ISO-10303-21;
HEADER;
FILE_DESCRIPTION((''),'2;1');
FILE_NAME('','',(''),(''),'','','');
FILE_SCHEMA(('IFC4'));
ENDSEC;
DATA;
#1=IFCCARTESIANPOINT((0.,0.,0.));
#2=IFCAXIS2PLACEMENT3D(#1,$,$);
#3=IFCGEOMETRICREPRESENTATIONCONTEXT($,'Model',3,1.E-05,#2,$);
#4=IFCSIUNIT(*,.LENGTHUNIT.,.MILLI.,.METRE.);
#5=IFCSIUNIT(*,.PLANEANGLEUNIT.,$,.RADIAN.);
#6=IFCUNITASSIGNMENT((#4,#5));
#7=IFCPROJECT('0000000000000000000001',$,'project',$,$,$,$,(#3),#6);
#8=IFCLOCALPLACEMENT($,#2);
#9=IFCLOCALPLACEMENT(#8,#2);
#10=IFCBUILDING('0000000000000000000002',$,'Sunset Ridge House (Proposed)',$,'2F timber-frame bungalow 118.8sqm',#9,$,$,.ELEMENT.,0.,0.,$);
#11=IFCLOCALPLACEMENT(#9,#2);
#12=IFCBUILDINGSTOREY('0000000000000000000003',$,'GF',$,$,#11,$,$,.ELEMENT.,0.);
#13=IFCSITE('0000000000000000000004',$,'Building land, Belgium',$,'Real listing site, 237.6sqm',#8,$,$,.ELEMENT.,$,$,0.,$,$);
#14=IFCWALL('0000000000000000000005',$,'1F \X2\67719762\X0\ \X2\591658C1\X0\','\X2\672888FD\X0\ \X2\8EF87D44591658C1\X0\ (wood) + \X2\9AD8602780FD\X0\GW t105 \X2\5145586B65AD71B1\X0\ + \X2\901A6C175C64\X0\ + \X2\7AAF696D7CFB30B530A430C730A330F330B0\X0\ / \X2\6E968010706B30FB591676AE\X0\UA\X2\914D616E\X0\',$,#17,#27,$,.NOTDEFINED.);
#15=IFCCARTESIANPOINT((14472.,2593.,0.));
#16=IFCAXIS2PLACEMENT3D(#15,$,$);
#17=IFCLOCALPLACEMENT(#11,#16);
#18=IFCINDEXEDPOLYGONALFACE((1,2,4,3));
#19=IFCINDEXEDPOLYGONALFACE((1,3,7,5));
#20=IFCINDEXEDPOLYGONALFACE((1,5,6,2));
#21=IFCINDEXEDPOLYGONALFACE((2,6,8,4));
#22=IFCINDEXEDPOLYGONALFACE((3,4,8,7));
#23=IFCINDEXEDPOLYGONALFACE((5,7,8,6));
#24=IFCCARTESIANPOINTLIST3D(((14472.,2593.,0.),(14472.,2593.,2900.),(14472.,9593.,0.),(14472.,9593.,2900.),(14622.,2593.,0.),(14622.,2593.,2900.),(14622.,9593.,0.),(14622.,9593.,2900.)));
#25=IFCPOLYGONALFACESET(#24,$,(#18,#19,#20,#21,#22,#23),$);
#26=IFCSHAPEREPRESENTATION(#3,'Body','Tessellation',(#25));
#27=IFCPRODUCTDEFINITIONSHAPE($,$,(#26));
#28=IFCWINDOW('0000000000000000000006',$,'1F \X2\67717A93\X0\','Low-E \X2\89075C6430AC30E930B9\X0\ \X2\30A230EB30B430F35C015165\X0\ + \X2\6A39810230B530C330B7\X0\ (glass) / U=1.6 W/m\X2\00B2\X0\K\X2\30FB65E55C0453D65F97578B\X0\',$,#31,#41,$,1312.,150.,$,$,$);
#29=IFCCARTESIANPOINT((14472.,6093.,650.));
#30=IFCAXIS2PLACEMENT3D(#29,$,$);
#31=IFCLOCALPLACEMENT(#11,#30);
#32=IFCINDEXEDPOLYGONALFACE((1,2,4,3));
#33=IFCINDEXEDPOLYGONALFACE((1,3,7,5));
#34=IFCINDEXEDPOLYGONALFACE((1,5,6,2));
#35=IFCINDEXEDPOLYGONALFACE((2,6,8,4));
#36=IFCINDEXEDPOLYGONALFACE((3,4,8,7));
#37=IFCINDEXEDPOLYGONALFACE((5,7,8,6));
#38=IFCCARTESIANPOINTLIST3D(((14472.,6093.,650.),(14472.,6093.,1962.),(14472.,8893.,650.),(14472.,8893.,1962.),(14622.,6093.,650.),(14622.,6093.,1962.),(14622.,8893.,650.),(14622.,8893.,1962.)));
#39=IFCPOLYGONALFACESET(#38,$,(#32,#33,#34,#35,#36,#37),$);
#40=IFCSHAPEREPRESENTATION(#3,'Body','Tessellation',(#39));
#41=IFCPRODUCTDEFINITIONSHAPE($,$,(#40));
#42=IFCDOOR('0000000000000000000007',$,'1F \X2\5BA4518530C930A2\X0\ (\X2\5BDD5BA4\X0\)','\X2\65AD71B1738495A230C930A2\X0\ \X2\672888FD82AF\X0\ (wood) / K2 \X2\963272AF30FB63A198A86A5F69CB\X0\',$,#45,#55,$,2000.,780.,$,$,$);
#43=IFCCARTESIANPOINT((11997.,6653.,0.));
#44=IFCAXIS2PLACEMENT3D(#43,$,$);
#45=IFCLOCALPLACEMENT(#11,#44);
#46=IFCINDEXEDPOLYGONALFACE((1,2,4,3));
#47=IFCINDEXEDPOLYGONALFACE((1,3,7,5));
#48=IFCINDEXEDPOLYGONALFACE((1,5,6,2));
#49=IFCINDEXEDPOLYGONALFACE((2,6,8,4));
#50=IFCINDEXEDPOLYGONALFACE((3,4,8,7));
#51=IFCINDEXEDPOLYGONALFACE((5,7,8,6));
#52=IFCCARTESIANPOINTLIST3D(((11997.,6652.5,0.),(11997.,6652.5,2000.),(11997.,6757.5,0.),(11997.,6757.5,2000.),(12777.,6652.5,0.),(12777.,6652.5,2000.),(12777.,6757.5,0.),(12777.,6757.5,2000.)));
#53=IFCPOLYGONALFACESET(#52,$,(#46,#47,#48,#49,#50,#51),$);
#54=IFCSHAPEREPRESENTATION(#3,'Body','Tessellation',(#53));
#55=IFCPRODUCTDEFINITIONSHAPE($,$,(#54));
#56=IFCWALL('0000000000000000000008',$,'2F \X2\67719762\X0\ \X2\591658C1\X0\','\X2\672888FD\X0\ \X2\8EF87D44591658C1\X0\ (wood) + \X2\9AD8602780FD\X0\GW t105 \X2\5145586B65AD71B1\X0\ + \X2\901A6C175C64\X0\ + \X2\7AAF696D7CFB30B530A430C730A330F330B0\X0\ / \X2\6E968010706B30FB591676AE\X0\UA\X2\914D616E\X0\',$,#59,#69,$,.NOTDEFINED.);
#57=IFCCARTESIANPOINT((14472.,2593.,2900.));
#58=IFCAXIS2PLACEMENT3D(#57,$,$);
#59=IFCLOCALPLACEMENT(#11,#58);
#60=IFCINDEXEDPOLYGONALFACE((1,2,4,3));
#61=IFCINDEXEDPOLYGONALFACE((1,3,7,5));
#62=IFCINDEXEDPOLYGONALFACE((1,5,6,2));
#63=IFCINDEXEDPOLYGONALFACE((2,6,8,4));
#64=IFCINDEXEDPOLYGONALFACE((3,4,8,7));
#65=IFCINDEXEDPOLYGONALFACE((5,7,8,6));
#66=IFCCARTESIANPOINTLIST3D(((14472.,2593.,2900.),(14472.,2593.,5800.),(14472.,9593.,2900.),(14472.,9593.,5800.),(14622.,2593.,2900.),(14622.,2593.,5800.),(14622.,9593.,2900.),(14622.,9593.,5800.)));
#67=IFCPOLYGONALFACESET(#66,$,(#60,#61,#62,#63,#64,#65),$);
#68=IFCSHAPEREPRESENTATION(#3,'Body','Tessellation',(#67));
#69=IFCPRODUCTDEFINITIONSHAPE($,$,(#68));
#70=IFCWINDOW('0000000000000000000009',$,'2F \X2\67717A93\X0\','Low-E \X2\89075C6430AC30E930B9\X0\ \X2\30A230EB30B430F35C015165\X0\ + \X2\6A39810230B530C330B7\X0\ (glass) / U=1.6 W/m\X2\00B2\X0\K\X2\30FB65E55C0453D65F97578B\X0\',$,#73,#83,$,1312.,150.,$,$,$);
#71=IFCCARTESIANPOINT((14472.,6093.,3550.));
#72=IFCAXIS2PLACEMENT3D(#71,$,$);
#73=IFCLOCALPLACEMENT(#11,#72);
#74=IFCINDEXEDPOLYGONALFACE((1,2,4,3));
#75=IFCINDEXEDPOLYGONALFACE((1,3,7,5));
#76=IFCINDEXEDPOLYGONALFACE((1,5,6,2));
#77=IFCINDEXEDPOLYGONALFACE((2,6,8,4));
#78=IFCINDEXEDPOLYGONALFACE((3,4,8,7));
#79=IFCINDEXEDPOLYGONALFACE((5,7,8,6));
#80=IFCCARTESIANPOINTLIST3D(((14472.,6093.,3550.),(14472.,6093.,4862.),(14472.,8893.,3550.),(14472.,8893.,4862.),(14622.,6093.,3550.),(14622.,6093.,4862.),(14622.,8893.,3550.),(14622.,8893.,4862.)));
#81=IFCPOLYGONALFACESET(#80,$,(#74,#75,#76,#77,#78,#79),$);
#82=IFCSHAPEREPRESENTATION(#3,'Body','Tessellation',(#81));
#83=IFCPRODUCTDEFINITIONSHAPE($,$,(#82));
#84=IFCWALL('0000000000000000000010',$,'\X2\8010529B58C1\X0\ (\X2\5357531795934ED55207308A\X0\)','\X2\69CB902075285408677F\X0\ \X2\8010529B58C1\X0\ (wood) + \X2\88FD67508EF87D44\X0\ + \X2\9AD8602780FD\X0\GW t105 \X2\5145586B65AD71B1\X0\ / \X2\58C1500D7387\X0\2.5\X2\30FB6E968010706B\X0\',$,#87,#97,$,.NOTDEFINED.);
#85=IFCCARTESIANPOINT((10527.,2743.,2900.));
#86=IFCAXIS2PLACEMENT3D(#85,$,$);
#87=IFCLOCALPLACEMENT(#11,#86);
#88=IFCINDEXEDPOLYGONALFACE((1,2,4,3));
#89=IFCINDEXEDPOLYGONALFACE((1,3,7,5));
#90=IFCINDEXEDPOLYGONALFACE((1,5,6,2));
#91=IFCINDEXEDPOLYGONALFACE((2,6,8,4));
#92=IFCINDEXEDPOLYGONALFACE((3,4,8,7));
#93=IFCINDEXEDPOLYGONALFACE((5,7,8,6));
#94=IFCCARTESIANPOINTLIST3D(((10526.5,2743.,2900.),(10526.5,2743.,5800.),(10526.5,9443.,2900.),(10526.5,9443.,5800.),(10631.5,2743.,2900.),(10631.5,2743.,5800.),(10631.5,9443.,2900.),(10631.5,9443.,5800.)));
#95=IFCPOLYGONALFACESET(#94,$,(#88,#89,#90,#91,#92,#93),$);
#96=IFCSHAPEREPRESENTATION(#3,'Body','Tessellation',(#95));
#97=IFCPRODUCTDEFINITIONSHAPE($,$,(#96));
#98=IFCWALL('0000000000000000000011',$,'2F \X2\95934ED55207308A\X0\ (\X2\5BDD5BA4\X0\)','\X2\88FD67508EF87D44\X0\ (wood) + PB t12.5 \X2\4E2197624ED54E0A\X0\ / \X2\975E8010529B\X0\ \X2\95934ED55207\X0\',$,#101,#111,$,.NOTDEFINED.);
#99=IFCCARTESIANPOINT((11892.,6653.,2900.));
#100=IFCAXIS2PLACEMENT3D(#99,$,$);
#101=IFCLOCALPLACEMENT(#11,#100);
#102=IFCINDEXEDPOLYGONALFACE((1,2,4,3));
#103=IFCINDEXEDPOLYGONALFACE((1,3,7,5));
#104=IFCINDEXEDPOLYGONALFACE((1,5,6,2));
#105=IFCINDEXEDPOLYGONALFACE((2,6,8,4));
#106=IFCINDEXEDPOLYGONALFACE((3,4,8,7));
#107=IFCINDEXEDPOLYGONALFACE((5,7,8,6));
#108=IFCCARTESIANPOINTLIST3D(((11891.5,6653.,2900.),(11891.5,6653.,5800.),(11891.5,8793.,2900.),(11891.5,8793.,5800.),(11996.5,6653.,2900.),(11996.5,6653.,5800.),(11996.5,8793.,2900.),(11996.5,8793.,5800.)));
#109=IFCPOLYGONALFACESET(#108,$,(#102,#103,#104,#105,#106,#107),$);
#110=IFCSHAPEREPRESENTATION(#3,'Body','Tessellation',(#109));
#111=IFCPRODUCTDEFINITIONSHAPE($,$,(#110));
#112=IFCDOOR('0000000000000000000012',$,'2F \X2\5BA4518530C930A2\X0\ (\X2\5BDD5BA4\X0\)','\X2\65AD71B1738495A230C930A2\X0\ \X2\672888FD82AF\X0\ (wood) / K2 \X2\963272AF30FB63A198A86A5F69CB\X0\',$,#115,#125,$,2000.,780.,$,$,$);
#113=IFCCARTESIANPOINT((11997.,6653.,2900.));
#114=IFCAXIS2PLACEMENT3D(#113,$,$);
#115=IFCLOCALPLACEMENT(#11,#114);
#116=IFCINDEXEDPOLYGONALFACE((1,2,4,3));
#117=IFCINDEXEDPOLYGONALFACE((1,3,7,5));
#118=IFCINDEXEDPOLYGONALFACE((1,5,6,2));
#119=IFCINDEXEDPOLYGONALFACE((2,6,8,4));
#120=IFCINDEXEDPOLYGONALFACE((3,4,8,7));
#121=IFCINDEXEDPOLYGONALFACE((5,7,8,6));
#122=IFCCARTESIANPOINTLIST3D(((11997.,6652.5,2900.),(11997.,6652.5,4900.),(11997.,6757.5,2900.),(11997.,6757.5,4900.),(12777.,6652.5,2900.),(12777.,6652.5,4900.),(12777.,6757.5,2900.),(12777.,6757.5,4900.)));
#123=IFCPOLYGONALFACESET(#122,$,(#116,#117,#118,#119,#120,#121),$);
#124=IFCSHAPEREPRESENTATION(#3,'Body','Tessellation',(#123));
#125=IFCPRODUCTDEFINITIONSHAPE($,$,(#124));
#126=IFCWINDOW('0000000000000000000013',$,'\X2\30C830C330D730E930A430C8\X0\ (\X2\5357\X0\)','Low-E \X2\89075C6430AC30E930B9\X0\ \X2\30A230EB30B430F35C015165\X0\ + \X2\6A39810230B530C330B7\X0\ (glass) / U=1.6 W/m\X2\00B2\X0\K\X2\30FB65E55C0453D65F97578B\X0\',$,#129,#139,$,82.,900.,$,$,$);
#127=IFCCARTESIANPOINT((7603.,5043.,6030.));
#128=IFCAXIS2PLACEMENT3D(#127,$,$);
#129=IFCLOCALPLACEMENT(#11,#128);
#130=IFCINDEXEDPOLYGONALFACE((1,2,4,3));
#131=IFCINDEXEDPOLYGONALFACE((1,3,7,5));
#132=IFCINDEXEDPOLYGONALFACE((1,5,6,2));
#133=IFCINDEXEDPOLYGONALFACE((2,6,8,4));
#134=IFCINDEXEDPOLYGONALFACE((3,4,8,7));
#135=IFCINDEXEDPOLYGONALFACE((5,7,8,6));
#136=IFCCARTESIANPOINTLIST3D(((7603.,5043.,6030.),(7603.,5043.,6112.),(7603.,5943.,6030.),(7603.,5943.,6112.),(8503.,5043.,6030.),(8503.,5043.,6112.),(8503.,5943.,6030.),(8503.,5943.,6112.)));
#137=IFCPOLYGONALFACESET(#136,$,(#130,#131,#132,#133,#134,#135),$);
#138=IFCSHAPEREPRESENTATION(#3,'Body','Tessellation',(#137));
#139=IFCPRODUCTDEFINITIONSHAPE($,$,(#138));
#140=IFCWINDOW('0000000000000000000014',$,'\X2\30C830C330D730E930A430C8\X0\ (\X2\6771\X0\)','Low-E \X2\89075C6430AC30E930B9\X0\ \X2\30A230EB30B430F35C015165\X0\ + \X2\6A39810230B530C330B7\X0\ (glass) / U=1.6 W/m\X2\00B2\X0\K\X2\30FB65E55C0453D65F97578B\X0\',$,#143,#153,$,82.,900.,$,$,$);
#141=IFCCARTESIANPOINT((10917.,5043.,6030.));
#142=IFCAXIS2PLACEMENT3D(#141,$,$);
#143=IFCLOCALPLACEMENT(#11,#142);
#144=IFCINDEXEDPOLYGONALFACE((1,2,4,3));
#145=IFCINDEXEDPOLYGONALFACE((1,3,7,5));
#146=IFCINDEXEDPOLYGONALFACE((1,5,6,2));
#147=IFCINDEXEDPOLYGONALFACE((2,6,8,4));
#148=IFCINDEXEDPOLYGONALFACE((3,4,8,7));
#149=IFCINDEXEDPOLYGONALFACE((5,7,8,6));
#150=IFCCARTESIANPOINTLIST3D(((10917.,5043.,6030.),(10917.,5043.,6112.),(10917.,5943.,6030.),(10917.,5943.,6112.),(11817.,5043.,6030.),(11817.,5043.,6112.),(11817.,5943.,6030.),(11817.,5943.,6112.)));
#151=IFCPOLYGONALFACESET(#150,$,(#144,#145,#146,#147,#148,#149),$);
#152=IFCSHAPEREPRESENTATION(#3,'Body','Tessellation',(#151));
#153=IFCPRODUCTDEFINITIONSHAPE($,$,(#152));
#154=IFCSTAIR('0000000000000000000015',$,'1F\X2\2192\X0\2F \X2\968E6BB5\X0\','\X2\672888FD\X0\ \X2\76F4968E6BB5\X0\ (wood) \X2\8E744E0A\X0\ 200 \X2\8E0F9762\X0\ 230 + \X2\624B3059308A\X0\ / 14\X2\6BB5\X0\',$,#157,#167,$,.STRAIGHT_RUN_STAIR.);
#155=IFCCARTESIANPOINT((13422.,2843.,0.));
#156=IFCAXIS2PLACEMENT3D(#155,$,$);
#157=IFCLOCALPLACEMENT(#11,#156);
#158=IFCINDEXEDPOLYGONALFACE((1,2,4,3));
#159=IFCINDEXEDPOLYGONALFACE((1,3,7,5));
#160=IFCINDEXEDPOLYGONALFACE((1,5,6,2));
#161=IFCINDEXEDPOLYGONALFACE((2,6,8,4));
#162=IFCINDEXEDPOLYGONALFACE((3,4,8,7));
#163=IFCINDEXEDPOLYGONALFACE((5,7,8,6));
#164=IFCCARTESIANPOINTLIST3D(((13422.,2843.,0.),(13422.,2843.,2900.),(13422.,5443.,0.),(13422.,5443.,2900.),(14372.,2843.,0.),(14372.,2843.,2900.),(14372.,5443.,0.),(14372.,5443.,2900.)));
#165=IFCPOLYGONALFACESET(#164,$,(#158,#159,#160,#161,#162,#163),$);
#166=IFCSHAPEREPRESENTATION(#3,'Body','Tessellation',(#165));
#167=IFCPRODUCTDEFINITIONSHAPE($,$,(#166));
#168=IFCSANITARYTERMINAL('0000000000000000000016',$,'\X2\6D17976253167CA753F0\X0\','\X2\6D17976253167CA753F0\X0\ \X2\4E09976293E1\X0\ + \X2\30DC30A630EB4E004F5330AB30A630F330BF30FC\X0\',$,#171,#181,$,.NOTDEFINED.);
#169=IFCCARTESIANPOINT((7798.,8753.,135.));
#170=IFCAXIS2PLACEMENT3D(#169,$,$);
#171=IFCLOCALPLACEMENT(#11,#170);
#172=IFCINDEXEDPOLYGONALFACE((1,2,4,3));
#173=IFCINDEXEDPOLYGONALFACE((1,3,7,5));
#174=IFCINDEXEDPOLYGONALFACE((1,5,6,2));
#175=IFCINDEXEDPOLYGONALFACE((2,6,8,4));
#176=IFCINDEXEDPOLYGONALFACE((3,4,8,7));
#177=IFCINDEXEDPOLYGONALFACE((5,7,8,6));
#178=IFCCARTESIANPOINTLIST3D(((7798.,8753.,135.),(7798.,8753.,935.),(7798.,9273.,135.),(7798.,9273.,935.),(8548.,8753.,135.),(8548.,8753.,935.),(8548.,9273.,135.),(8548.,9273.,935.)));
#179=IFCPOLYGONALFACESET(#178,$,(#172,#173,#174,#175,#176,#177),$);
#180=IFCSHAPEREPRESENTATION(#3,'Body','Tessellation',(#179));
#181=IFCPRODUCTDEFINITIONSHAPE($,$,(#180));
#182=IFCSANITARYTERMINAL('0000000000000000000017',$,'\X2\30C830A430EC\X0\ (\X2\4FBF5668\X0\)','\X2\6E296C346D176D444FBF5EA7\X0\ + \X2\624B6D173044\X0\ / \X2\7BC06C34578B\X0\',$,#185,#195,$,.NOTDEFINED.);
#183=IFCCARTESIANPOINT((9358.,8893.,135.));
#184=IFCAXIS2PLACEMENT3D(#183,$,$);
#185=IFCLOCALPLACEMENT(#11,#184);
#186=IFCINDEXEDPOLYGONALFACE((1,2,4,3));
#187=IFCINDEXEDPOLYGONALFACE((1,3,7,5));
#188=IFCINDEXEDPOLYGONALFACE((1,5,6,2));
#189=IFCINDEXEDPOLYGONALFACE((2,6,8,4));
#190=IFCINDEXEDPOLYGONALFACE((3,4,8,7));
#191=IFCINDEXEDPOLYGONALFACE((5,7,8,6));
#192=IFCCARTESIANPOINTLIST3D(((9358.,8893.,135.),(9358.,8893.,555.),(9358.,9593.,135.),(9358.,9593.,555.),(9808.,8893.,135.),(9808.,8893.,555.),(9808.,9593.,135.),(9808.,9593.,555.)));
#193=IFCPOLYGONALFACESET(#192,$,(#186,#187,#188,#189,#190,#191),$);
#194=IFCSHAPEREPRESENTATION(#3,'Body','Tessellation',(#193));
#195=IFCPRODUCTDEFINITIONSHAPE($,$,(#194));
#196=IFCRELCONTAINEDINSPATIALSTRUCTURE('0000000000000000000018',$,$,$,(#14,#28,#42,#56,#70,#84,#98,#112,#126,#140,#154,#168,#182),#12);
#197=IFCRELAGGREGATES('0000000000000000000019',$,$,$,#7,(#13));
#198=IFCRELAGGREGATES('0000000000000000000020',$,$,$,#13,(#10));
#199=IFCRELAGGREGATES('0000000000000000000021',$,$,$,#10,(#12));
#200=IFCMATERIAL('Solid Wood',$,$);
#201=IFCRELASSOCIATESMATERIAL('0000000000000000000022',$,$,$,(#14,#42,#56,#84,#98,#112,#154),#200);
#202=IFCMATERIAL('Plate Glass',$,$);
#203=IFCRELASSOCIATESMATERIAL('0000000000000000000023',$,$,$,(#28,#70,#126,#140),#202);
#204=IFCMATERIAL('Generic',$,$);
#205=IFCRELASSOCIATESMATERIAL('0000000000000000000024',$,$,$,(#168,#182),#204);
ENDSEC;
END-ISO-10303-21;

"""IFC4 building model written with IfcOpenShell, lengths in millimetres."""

from ifc_helpers import new_model, si_unit, frame, frame_2d, origin, place, context, project, spatial, rectangle, extrude, material, element, fill, save


model = new_model("IFC4")

# Units and contexts
model_context = context("Model", 3, precision=1e-05, world=origin())
ifc_project = project(units=[si_unit("LENGTHUNIT", "METRE", prefix="MILLI"), si_unit("PLANEANGLEUNIT", "RADIAN")], contexts=[model_context])

# Site, building, storey
site_placement = place(None, origin())
site = spatial("IfcSite", under=ifc_project, at=site_placement, Name="Building land, Belgium", ObjectType="Real listing site, 237.6sqm", CompositionType="ELEMENT", RefElevation=0.0)
building_placement = place(site_placement, origin())
building = spatial("IfcBuilding", under=site, at=building_placement, Name="Sunset Ridge House (Proposed)", ObjectType="2F timber-frame bungalow 118.8sqm", CompositionType="ELEMENT", ElevationOfRefHeight=0.0, ElevationOfTerrain=0.0)
storey_placement = place(building_placement, origin())
storey = spatial("IfcBuildingStorey", under=building, at=storey_placement, Name="GF", CompositionType="ELEMENT", Elevation=0.0)

# Wall, opening, window
ifc_material_1 = material(Name="Solid Wood")
wall_1_placement = place(storey_placement, frame((14472.0, 2593.0, 0.0)))
wall_1 = element("IfcWall", 1, at=wall_1_placement, inside=storey, material=ifc_material_1, Name="1F 東面 外壁", Description="木製 軸組外壁 (wood) + 高性能GW t105 充填断熱 + 通気層 + 窯業系サイディング / 準耐火・外皮UA配慮", PredefinedType="NOTDEFINED", context=model_context, shape_type="SweptSolid", body=[
    extrude(rectangle(XDim=150.0, YDim=7000.0, at=frame_2d((75.0, 3500.0))), frame((14472.0, 2593.0, 0.0)), (0.0, 0.0, 1.0), 2900.0),
])
opening_1_placement = place(storey_placement, frame((14472.0, 6093.0, 650.0)))
opening_1 = element("IfcOpeningElement", 2, at=opening_1_placement, cuts=wall_1, PredefinedType="NOTDEFINED", context=model_context, shape_type="SweptSolid", body=[
    extrude(rectangle(XDim=150.0, YDim=2800.0, at=frame_2d((75.0, 1400.0))), frame((14472.0, 6093.0, 650.0)), (0.0, 0.0, 1.0), 1312.0),
])
ifc_material_2 = material(Name="Plate Glass")
window_1_placement = place(storey_placement, frame((14472.0, 6093.0, 650.0)))
window_1 = element("IfcWindow", 3, at=window_1_placement, inside=storey, material=ifc_material_2, Name="1F 東窓", Description="Low-E 複層ガラス アルゴン封入 + 樹脂サッシ (glass) / U=1.6 W/m²K・日射取得型", OverallHeight=1312.0, OverallWidth=150.0, context=model_context, shape_type="SweptSolid", body=[
    extrude(rectangle(XDim=150.0, YDim=2800.0, at=frame_2d((75.0, 1400.0))), frame((14472.0, 6093.0, 650.0)), (0.0, 0.0, 1.0), 1312.0),
])
fill(opening_1, window_1)

# Door
door_1_placement = place(storey_placement, frame((11997.0, 6653.0, 0.0)))
element("IfcDoor", 4, at=door_1_placement, inside=storey, material=ifc_material_1, Name="1F 室内ドア (寝室)", Description="断熱玄関ドア 木製芯 (wood) / K2 防犯・採風機構", OverallHeight=2000.0, OverallWidth=780.0, context=model_context, shape_type="SweptSolid", body=[
    extrude(rectangle(XDim=780.0, YDim=105.0, at=frame_2d((390.0, 52.0))), frame((11997.0, 6653.0, 0.0)), (0.0, 0.0, 1.0), 2000.0),
])

# Wall, opening, window
wall_2_placement = place(storey_placement, frame((14472.0, 2593.0, 2900.0)))
wall_2 = element("IfcWall", 5, at=wall_2_placement, inside=storey, material=ifc_material_1, Name="2F 東面 外壁", Description="木製 軸組外壁 (wood) + 高性能GW t105 充填断熱 + 通気層 + 窯業系サイディング / 準耐火・外皮UA配慮", PredefinedType="NOTDEFINED", context=model_context, shape_type="SweptSolid", body=[
    extrude(rectangle(XDim=150.0, YDim=7000.0, at=frame_2d((75.0, 3500.0))), frame((14472.0, 2593.0, 2900.0)), (0.0, 0.0, 1.0), 2900.0),
])
opening_2_placement = place(storey_placement, frame((14472.0, 6093.0, 3550.0)))
opening_2 = element("IfcOpeningElement", 6, at=opening_2_placement, cuts=wall_2, PredefinedType="NOTDEFINED", context=model_context, shape_type="SweptSolid", body=[
    extrude(rectangle(XDim=150.0, YDim=2800.0, at=frame_2d((75.0, 1400.0))), frame((14472.0, 6093.0, 3550.0)), (0.0, 0.0, 1.0), 1312.0),
])
window_2_placement = place(storey_placement, frame((14472.0, 6093.0, 3550.0)))
window_2 = element("IfcWindow", 7, at=window_2_placement, inside=storey, material=ifc_material_2, Name="2F 東窓", Description="Low-E 複層ガラス アルゴン封入 + 樹脂サッシ (glass) / U=1.6 W/m²K・日射取得型", OverallHeight=1312.0, OverallWidth=150.0, context=model_context, shape_type="SweptSolid", body=[
    extrude(rectangle(XDim=150.0, YDim=2800.0, at=frame_2d((75.0, 1400.0))), frame((14472.0, 6093.0, 3550.0)), (0.0, 0.0, 1.0), 1312.0),
])
fill(opening_2, window_2)

# Walls
wall_3_placement = place(storey_placement, frame((10527.0, 2743.0, 2900.0)))
element("IfcWall", 8, at=wall_3_placement, inside=storey, material=ifc_material_1, Name="耐力壁 (南北間仕切り)", Description="構造用合板 耐力壁 (wood) + 製材軸組 + 高性能GW t105 充填断熱 / 壁倍率2.5・準耐火", PredefinedType="NOTDEFINED", context=model_context, shape_type="SweptSolid", body=[
    extrude(rectangle(XDim=105.0, YDim=6700.0, at=frame_2d((52.0, 3350.0))), frame((10527.0, 2743.0, 2900.0)), (0.0, 0.0, 1.0), 2900.0),
])
wall_4_placement = place(storey_placement, frame((11892.0, 6653.0, 2900.0)))
element("IfcWall", 9, at=wall_4_placement, inside=storey, material=ifc_material_1, Name="2F 間仕切り (寝室)", Description="製材軸組 (wood) + PB t12.5 両面仕上 / 非耐力 間仕切", PredefinedType="NOTDEFINED", context=model_context, shape_type="SweptSolid", body=[
    extrude(rectangle(XDim=105.0, YDim=2140.0, at=frame_2d((52.0, 1070.0))), frame((11892.0, 6653.0, 2900.0)), (0.0, 0.0, 1.0), 2900.0),
])

# Door
door_2_placement = place(storey_placement, frame((11997.0, 6653.0, 2900.0)))
element("IfcDoor", 10, at=door_2_placement, inside=storey, material=ifc_material_1, Name="2F 室内ドア (寝室)", Description="断熱玄関ドア 木製芯 (wood) / K2 防犯・採風機構", OverallHeight=2000.0, OverallWidth=780.0, context=model_context, shape_type="SweptSolid", body=[
    extrude(rectangle(XDim=780.0, YDim=105.0, at=frame_2d((390.0, 52.0))), frame((11997.0, 6653.0, 2900.0)), (0.0, 0.0, 1.0), 2000.0),
])

# Windows
window_3_placement = place(storey_placement, frame((7603.0, 5043.0, 6030.0)))
element("IfcWindow", 11, at=window_3_placement, inside=storey, material=ifc_material_2, Name="トップライト (南)", Description="Low-E 複層ガラス アルゴン封入 + 樹脂サッシ (glass) / U=1.6 W/m²K・日射取得型", OverallHeight=82.0, OverallWidth=900.0, context=model_context, shape_type="SweptSolid", body=[
    extrude(rectangle(XDim=900.0, YDim=900.0, at=frame_2d((450.0, 450.0))), frame((7603.0, 5043.0, 6030.0)), (0.0, 0.0, 1.0), 82.0),
])
window_4_placement = place(storey_placement, frame((10917.0, 5043.0, 6030.0)))
element("IfcWindow", 12, at=window_4_placement, inside=storey, material=ifc_material_2, Name="トップライト (東)", Description="Low-E 複層ガラス アルゴン封入 + 樹脂サッシ (glass) / U=1.6 W/m²K・日射取得型", OverallHeight=82.0, OverallWidth=900.0, context=model_context, shape_type="SweptSolid", body=[
    extrude(rectangle(XDim=900.0, YDim=900.0, at=frame_2d((450.0, 450.0))), frame((10917.0, 5043.0, 6030.0)), (0.0, 0.0, 1.0), 82.0),
])

# Stair
stair_placement = place(storey_placement, frame((13422.0, 2843.0, 0.0)))
element("IfcStair", 13, at=stair_placement, inside=storey, material=ifc_material_1, Name="1F→2F 階段", Description="木製 直階段 (wood) 蹴上 200 踏面 230 + 手すり / 14段", PredefinedType="STRAIGHT_RUN_STAIR", context=model_context, shape_type="SweptSolid", body=[
    extrude(rectangle(XDim=950.0, YDim=2600.0, at=frame_2d((475.0, 1300.0))), frame((13422.0, 2843.0, 0.0)), (0.0, 0.0, 1.0), 2900.0),
])

# Sanitary terminals
ifc_material_3 = material(Name="Generic")
sanitary_terminal_1_placement = place(storey_placement, frame((7798.0, 8753.0, 135.0)))
element("IfcSanitaryTerminal", 14, at=sanitary_terminal_1_placement, inside=storey, material=ifc_material_3, Name="洗面化粧台", Description="洗面化粧台 三面鏡 + ボウル一体カウンター", PredefinedType="NOTDEFINED", context=model_context, shape_type="SweptSolid", body=[
    extrude(rectangle(XDim=750.0, YDim=520.0, at=frame_2d((375.0, 260.0))), frame((7798.0, 8753.0, 135.0)), (0.0, 0.0, 1.0), 800.0),
])
sanitary_terminal_2_placement = place(storey_placement, frame((9358.0, 8893.0, 135.0)))
element("IfcSanitaryTerminal", 15, at=sanitary_terminal_2_placement, inside=storey, material=ifc_material_3, Name="トイレ (便器)", Description="温水洗浄便座 + 手洗い / 節水型", PredefinedType="NOTDEFINED", context=model_context, shape_type="SweptSolid", body=[
    extrude(rectangle(XDim=450.0, YDim=700.0, at=frame_2d((225.0, 350.0))), frame((9358.0, 8893.0, 135.0)), (0.0, 0.0, 1.0), 420.0),
])

save(model, "model.ifc")
